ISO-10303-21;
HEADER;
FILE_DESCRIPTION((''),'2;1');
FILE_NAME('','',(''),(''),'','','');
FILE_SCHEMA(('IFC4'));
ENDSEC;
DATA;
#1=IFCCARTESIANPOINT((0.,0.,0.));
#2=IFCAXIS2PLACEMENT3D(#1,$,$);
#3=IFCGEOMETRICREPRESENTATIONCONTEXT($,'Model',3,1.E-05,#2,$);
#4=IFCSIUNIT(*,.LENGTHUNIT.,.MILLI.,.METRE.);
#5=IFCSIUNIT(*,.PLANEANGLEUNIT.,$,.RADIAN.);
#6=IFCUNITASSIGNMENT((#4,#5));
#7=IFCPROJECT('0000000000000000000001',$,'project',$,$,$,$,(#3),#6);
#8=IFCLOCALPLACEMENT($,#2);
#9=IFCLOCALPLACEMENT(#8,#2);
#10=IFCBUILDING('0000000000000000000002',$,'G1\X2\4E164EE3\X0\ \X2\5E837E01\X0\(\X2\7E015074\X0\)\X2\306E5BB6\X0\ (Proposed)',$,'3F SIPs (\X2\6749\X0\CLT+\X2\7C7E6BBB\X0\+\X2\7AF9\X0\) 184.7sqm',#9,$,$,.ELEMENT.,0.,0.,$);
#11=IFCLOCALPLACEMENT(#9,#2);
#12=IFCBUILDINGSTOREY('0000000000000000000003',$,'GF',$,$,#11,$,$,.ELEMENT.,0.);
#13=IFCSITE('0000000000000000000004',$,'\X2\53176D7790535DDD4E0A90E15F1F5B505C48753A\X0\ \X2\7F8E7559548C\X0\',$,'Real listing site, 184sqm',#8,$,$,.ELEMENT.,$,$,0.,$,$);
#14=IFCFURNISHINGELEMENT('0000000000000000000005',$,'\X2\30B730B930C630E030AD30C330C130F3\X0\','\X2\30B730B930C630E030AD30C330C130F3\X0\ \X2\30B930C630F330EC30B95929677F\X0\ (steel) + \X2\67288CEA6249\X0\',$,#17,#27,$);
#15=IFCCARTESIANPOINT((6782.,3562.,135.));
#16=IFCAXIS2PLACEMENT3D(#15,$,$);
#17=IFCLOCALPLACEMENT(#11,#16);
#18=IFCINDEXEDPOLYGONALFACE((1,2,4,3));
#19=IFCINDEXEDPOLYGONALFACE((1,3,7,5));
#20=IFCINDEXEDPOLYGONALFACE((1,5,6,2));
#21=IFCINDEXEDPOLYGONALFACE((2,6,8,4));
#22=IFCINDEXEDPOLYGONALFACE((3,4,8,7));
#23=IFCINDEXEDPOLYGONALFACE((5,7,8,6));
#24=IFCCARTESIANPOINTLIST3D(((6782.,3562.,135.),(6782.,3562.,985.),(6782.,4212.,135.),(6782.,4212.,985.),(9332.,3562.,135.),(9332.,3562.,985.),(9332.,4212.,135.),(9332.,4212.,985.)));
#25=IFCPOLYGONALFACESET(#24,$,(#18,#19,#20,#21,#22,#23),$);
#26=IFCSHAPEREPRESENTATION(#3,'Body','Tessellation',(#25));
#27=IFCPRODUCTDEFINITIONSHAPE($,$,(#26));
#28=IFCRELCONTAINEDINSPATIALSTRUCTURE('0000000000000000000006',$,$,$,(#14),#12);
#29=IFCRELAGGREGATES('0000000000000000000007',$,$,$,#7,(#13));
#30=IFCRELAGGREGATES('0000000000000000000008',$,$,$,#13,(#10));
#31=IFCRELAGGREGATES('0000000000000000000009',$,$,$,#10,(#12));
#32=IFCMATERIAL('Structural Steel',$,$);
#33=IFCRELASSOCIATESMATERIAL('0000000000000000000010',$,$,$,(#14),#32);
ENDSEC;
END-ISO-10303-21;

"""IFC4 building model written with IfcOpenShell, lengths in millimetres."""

from ifc_helpers import new_model, si_unit, frame, frame_2d, origin, place, context, project, spatial, rectangle, extrude, material, element, save


model = new_model("IFC4")

# Units and contexts
model_context = context("Model", 3, precision=1e-05, world=origin())
ifc_project = project(units=[si_unit("LENGTHUNIT", "METRE", prefix="MILLI"), si_unit("PLANEANGLEUNIT", "RADIAN")], contexts=[model_context])

# Site, building, storey
site_placement = place(None, origin())
site = spatial("IfcSite", under=ifc_project, at=site_placement, Name="北海道川上郡弟子屈町 美留和", ObjectType="Real listing site, 184sqm", CompositionType="ELEMENT", RefElevation=0.0)
building_placement = place(site_placement, origin())
building = spatial("IfcBuilding", under=site, at=building_placement, Name="G1世代 広縁(縁側)の家 (Proposed)", ObjectType="3F SIPs (杉CLT+籾殻+竹) 184.7sqm", CompositionType="ELEMENT", ElevationOfRefHeight=0.0, ElevationOfTerrain=0.0)
storey_placement = place(building_placement, origin())
storey = spatial("IfcBuildingStorey", under=building, at=storey_placement, Name="GF", CompositionType="ELEMENT", Elevation=0.0)

# Furnishing element
ifc_material_1 = material(Name="Structural Steel")
furnishing_1_placement = place(storey_placement, frame((6782.0, 3562.0, 135.0)))
element("IfcFurnishingElement", 1, at=furnishing_1_placement, inside=storey, material=ifc_material_1, Name="システムキッチン", Description="システムキッチン ステンレス天板 (steel) + 木質扉", context=model_context, shape_type="SweptSolid", body=[
    extrude(rectangle(XDim=2550.0, YDim=650.0, at=frame_2d((1275.0, 325.0))), frame((6782.0, 3562.0, 135.0)), (0.0, 0.0, 1.0), 850.0),
])

save(model, "model.ifc")
